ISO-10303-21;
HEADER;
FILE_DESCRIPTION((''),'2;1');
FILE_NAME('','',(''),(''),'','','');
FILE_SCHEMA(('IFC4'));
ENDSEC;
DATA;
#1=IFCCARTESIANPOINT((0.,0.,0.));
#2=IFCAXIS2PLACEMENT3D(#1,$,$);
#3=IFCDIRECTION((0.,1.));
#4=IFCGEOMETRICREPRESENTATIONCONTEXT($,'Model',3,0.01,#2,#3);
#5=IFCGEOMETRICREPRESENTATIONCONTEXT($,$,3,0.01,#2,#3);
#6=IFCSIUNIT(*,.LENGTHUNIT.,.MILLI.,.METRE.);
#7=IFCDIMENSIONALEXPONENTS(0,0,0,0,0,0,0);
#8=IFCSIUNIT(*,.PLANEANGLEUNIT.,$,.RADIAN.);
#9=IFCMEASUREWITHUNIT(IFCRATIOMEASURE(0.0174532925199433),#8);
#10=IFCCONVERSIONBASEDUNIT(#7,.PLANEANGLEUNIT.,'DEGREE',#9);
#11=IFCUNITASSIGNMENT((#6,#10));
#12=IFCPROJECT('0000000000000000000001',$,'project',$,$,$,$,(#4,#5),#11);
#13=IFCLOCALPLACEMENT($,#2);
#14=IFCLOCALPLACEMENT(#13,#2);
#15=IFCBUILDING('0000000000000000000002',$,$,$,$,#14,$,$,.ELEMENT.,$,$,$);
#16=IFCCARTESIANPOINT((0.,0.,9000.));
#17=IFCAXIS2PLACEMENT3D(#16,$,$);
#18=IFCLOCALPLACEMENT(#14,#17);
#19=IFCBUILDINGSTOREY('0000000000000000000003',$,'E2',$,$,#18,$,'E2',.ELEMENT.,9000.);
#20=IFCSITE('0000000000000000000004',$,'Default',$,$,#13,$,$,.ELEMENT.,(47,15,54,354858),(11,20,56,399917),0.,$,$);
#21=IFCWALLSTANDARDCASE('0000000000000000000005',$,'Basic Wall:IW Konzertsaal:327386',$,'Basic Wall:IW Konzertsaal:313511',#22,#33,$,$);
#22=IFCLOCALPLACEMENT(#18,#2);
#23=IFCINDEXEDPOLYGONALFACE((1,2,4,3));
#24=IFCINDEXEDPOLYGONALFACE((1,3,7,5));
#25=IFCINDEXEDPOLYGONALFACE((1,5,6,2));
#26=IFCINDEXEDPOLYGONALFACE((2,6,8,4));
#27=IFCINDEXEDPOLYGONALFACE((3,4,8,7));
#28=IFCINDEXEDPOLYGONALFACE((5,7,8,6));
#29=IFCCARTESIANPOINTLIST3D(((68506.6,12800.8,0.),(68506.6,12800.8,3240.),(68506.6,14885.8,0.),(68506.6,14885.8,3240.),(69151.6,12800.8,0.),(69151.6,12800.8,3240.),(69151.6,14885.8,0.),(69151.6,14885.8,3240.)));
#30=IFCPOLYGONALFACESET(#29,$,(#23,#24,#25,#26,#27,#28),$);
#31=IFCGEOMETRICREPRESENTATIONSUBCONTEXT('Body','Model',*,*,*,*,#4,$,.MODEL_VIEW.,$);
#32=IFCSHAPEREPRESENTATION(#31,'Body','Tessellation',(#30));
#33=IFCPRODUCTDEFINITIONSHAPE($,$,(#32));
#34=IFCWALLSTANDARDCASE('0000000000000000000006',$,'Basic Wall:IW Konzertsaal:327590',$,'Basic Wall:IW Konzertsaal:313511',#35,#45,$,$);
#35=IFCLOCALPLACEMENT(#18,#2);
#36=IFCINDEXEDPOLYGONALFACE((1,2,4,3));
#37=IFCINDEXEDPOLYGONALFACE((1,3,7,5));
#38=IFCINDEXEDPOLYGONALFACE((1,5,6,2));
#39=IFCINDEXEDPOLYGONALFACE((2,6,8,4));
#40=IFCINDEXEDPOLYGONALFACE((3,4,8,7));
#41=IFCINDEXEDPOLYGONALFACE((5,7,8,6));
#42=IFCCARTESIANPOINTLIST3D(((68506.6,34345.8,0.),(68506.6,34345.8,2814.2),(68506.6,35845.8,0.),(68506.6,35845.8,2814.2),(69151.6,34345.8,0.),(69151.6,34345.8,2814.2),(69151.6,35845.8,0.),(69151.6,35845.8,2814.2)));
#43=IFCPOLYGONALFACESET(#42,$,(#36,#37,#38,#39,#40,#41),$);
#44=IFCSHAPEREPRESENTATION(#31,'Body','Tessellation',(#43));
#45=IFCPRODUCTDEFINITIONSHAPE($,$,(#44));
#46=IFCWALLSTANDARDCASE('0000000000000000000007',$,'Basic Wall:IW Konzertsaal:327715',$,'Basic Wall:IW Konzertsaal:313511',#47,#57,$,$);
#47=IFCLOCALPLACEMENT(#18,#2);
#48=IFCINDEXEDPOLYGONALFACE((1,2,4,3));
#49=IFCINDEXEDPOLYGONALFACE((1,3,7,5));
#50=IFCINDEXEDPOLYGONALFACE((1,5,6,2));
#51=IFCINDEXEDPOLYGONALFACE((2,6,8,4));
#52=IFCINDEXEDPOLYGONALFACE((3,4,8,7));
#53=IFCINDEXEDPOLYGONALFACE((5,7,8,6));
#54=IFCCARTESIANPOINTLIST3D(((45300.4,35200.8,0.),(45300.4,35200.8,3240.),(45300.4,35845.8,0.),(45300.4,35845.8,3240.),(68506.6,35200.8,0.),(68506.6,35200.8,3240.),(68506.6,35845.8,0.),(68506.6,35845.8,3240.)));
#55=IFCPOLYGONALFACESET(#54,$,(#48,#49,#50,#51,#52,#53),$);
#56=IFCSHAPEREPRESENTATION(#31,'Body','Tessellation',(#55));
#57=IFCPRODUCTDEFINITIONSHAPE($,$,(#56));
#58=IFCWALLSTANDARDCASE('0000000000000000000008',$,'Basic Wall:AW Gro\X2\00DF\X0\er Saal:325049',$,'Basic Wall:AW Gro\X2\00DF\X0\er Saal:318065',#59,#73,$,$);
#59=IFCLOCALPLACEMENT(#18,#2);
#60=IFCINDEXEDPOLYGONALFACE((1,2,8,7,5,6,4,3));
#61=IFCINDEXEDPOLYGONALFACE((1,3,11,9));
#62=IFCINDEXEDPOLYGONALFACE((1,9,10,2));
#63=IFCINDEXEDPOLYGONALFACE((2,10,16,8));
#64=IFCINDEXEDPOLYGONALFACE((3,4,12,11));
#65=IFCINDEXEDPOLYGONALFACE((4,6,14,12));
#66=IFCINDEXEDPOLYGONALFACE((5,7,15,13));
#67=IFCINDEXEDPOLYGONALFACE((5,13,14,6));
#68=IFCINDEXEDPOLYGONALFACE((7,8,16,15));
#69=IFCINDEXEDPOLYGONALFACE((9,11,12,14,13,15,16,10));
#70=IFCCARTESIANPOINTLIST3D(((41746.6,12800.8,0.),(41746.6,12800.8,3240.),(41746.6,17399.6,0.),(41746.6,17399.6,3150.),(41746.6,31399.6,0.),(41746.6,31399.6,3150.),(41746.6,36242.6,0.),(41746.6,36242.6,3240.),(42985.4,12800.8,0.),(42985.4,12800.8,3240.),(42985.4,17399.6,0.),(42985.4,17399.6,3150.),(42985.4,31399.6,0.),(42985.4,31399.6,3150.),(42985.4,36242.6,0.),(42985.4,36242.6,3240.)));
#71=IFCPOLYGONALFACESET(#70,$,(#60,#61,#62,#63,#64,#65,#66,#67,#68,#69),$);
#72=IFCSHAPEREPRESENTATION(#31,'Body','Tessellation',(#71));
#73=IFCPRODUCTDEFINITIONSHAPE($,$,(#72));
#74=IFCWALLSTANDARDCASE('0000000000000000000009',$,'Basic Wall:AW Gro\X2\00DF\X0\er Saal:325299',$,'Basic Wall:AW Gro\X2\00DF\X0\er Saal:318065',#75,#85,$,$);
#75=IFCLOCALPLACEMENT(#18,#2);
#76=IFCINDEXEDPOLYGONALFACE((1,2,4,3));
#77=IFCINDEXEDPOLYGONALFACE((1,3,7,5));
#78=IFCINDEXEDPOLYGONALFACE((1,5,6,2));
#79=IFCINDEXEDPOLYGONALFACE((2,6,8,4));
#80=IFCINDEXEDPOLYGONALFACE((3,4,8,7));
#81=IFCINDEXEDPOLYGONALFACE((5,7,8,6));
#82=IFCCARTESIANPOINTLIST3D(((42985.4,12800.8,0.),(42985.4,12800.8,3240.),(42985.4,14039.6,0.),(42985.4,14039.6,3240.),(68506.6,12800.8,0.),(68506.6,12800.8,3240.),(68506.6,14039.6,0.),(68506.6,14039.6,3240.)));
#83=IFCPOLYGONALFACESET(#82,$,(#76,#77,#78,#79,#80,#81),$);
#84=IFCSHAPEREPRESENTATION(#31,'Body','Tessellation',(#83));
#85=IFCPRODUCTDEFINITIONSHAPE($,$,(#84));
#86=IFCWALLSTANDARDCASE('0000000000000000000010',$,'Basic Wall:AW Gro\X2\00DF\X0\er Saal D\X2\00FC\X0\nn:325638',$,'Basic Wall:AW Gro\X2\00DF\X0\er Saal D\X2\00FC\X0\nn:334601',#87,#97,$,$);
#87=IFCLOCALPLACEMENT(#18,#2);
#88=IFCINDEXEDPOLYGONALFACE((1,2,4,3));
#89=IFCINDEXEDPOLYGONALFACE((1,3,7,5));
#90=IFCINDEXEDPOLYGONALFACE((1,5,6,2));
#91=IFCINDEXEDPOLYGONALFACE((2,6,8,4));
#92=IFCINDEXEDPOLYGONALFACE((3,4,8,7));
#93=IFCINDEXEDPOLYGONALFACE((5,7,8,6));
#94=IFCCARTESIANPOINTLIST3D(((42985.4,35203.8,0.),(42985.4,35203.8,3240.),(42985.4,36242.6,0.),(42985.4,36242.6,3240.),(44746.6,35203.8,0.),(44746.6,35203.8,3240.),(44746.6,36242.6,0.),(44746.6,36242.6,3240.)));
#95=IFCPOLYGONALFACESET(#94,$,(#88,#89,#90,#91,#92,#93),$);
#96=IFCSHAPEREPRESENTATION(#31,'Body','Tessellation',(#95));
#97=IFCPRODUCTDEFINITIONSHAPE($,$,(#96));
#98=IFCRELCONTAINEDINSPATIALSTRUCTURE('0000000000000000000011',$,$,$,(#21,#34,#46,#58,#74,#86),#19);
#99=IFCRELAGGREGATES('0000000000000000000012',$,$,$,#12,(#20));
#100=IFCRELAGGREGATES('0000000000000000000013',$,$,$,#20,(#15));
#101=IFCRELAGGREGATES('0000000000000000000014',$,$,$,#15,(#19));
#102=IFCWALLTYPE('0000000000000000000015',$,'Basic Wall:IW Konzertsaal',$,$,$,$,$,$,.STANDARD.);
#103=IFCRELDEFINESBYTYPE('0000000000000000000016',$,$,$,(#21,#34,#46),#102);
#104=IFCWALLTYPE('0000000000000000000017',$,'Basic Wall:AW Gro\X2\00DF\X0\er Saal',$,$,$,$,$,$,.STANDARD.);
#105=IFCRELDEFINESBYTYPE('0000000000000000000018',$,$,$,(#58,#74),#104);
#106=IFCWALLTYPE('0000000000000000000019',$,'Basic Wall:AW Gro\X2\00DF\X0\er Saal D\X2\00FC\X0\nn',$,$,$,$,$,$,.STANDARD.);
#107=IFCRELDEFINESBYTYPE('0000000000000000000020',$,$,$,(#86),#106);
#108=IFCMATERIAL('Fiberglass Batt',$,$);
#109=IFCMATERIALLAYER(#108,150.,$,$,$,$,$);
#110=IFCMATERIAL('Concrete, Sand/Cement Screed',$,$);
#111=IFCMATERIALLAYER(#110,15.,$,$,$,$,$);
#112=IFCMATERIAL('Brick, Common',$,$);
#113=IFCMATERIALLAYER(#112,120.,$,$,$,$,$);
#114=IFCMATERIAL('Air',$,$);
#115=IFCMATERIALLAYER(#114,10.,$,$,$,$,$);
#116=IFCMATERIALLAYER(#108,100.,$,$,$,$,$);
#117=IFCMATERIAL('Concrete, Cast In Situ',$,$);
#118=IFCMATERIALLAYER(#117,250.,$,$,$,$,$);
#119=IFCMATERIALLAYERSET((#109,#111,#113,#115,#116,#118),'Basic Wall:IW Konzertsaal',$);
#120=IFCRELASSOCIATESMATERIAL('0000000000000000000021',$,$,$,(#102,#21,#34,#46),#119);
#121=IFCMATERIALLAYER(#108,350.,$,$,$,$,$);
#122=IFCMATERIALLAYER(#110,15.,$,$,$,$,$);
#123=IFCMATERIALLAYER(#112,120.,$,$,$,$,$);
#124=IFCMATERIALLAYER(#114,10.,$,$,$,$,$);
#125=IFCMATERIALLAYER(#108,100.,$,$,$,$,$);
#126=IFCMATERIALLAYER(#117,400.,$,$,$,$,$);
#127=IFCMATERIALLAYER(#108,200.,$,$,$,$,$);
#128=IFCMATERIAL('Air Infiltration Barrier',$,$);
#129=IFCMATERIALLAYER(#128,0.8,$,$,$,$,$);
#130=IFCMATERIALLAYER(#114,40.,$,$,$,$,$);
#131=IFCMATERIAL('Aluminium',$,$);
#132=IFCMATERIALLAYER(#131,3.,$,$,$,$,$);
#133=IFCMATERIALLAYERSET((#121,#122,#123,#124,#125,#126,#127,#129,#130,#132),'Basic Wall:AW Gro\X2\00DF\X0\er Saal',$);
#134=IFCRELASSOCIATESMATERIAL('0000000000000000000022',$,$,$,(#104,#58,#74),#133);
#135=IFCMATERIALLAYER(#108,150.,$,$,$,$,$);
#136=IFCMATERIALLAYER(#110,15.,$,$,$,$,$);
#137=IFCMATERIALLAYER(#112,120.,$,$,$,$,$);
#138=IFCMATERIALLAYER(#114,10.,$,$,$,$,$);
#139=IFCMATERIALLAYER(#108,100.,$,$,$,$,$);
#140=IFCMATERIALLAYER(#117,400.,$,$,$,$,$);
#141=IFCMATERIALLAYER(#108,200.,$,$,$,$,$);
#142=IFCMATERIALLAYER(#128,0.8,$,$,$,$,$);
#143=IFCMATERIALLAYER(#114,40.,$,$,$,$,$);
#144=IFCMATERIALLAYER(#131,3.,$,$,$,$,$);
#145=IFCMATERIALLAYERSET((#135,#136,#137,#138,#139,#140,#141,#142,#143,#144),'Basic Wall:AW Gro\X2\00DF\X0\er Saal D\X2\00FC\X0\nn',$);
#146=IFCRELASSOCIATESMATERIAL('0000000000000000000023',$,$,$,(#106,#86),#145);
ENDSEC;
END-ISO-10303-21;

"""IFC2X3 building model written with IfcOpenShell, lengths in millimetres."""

from ifc_helpers import new_model, entity, si_unit, converted_unit, direction, frame, frame_2d, origin, place, context, subcontext, project, spatial, polyline, rectangle, extrude, clip, bounded_halfspace, material, layer, layer_set, layer_usage, type_object, element, save


model = new_model("IFC2X3")

# Units and contexts
model_context = context("Model", 3, precision=0.01, world=origin(), true_north=direction((0.0, 1.0)))
context_of_model = context(None, 3, precision=0.01, world=origin(), true_north=direction((0.0, 1.0)))
body_context = subcontext(model_context, "Body", "Model", "MODEL_VIEW")
ifc_project = project(units=[si_unit("LENGTHUNIT", "METRE", prefix="MILLI"), converted_unit("PLANEANGLEUNIT", "DEGREE", entity("IfcRatioMeasure", 0.0174532925199433), si_unit("PLANEANGLEUNIT", "RADIAN"), dimensions=[0, 0, 0, 0, 0, 0, 0])], contexts=[model_context, context_of_model])

# Site, building, storey
site_placement = place(None, origin())
site = spatial("IfcSite", under=ifc_project, at=site_placement, Name="Default", CompositionType="ELEMENT", RefLatitude=(47, 15, 54, 354858), RefLongitude=(11, 20, 56, 399917), RefElevation=0.0)
building_placement = place(site_placement, origin())
building = spatial("IfcBuilding", under=site, at=building_placement, CompositionType="ELEMENT")
storey_placement = place(building_placement, frame((0.0, 0.0, 9000.0)))
storey = spatial("IfcBuildingStorey", under=building, at=storey_placement, Name="E2", LongName="E2", CompositionType="ELEMENT", Elevation=9000.0)

# Shared definitions
ifc_material_1 = material(Name="Concrete, Sand/Cement Screed")
ifc_material_2 = material(Name="Air Infiltration Barrier")
ifc_material_3 = material(Name="Fiberglass Batt")

# Shared definitions
ifc_material_4 = material(Name="Concrete, Cast In Situ")

# Shared definitions
ifc_material_5 = material(Name="Air")
ifc_material_6 = material(Name="Aluminium")

# Walls
ifc_layer_1 = layer(ifc_material_3, 150.0)
ifc_layer_2 = layer(ifc_material_1, 15.0)
ifc_material_7 = material(Name="Brick, Common")
ifc_layer_3 = layer(ifc_material_7, 120.0)
ifc_layer_4 = layer(ifc_material_5, 10.0)
ifc_layer_5 = layer(ifc_material_3, 100.0)
ifc_layer_6 = layer(ifc_material_4, 250.0)
ifc_layer_set_1 = layer_set([ifc_layer_1, ifc_layer_2, ifc_layer_3, ifc_layer_4, ifc_layer_5, ifc_layer_6], Name="Basic Wall:IW Konzertsaal")
wall_type_1 = type_object("IfcWallType", Name="Basic Wall:IW Konzertsaal", PredefinedType="STANDARD", material=ifc_layer_set_1)
ifc_layer_usage_1 = layer_usage(ifc_layer_set_1, "AXIS2", "NEGATIVE", 322.5)
wall_1_placement = place(storey_placement, frame((68829.1, 12800.8, 0.0), z_axis=(0.0, 0.0, 1.0), x_axis=(0.0, 1.0, 0.0)))
element("IfcWallStandardCase", 1, at=wall_1_placement, inside=storey, type_object=wall_type_1, material=ifc_layer_usage_1, Name="Basic Wall:IW Konzertsaal:327386", ObjectType="Basic Wall:IW Konzertsaal:313511", context=body_context, shape_type="SweptSolid", body=[
    extrude(rectangle(XDim=2085.0, YDim=645.0, at=frame_2d((1042.5, 0.0), x_axis=(-1.0, 0.0))), origin(), (0.0, 0.0, 1.0), 3240.0),
])
ifc_layer_usage_2 = layer_usage(ifc_layer_set_1, "AXIS2", "NEGATIVE", 322.5)
wall_2_placement = place(storey_placement, frame((68829.1, 34345.8, 0.0), z_axis=(0.0, 0.0, 1.0), x_axis=(0.0, 1.0, 0.0)))
element("IfcWallStandardCase", 2, at=wall_2_placement, inside=storey, type_object=wall_type_1, material=ifc_layer_usage_2, Name="Basic Wall:IW Konzertsaal:327590", ObjectType="Basic Wall:IW Konzertsaal:313511", context=body_context, shape_type="Clipping", body=[
    clip(extrude(rectangle(XDim=1500.0, YDim=645.0, at=frame_2d((750.0, 0.0), x_axis=(-1.0, 0.0))), origin(), (0.0, 0.0, 1.0), 2814.2), bounded_halfspace(frame((0.0, -322.5, 2814.2), z_axis=(0.0, 0.0, -1.0), x_axis=(0.0, -1.0, 0.0)), True, frame((0.0, -322.5, 2814.2)), polyline([(0.0, 0.0), (855.0, 0.0), (855.0, 645.0), (0.0, 645.0), (0.0, 0.0)]))),
])
ifc_layer_usage_3 = layer_usage(ifc_layer_set_1, "AXIS2", "NEGATIVE", 322.5)
wall_3_placement = place(storey_placement, frame((68506.6, 35523.3, 0.0), z_axis=(0.0, 0.0, 1.0), x_axis=(-1.0, 0.0, 0.0)))
element("IfcWallStandardCase", 3, at=wall_3_placement, inside=storey, type_object=wall_type_1, material=ifc_layer_usage_3, Name="Basic Wall:IW Konzertsaal:327715", ObjectType="Basic Wall:IW Konzertsaal:313511", context=body_context, shape_type="SweptSolid", body=[
    extrude(rectangle(XDim=23206.2, YDim=645.0, at=frame_2d((11603.1, 0.0), x_axis=(-1.0, 0.0))), origin(), (0.0, 0.0, 1.0), 3240.0),
])

# Wall, opening
ifc_layer_7 = layer(ifc_material_3, 350.0)
ifc_layer_8 = layer(ifc_material_1, 15.0)
ifc_layer_9 = layer(ifc_material_7, 120.0)
ifc_layer_10 = layer(ifc_material_5, 10.0)
ifc_layer_11 = layer(ifc_material_3, 100.0)
ifc_layer_12 = layer(ifc_material_4, 400.0)
ifc_layer_13 = layer(ifc_material_3, 200.0)
ifc_layer_14 = layer(ifc_material_2, 0.8)
ifc_layer_15 = layer(ifc_material_5, 40.0)
ifc_layer_16 = layer(ifc_material_6, 3.0)
ifc_layer_set_2 = layer_set([ifc_layer_7, ifc_layer_8, ifc_layer_9, ifc_layer_10, ifc_layer_11, ifc_layer_12, ifc_layer_13, ifc_layer_14, ifc_layer_15, ifc_layer_16], Name="Basic Wall:AW Großer Saal")
ifc_layer_usage_4 = layer_usage(ifc_layer_set_2, "AXIS2", "NEGATIVE", 619.4)
wall_type_2 = type_object("IfcWallType", Name="Basic Wall:AW Großer Saal", PredefinedType="STANDARD", material=ifc_layer_set_2)
wall_4_placement = place(storey_placement, frame((42366.0, 36242.6, 0.0), z_axis=(0.0, 0.0, 1.0), x_axis=(0.0, -1.0, 0.0)))
wall_4 = element("IfcWallStandardCase", 4, at=wall_4_placement, inside=storey, type_object=wall_type_2, material=ifc_layer_usage_4, Name="Basic Wall:AW Großer Saal:325049", ObjectType="Basic Wall:AW Großer Saal:318065", context=body_context, shape_type="SweptSolid", body=[
    extrude(rectangle(XDim=23441.7, YDim=1238.8, at=frame_2d((11720.9, 0.0), x_axis=(-1.0, 0.0))), origin(), (0.0, 0.0, 1.0), 3240.0),
])
opening_1_placement = place(wall_4_placement, frame((18842.9, 619.4, 0.0)))
element("IfcOpeningElement", 5, at=opening_1_placement, cuts=wall_4, ObjectType="Opening", context=body_context, shape_type="SweptSolid", body=[
    extrude(rectangle(XDim=3150.0, YDim=14000.0, at=frame_2d((1575.0, 7000.0), x_axis=(-1.0, 0.0))), frame((0.0, 0.0, 0.0), z_axis=(0.0, -1.0, 0.0), x_axis=(0.0, 0.0, 1.0)), (0.0, 0.0, 1.0), 1238.8),
])

# Walls
ifc_layer_usage_5 = layer_usage(ifc_layer_set_2, "AXIS2", "NEGATIVE", 619.4)
wall_5_placement = place(storey_placement, frame((42985.4, 13420.2, 0.0)))
element("IfcWallStandardCase", 6, at=wall_5_placement, inside=storey, type_object=wall_type_2, material=ifc_layer_usage_5, Name="Basic Wall:AW Großer Saal:325299", ObjectType="Basic Wall:AW Großer Saal:318065", context=body_context, shape_type="SweptSolid", body=[
    extrude(rectangle(XDim=25521.2, YDim=1238.8, at=frame_2d((12760.6, 0.0), x_axis=(-1.0, 0.0))), origin(), (0.0, 0.0, 1.0), 3240.0),
])
ifc_layer_17 = layer(ifc_material_3, 150.0)
ifc_layer_18 = layer(ifc_material_1, 15.0)
ifc_layer_19 = layer(ifc_material_7, 120.0)
ifc_layer_20 = layer(ifc_material_5, 10.0)
ifc_layer_21 = layer(ifc_material_3, 100.0)
ifc_layer_22 = layer(ifc_material_4, 400.0)
ifc_layer_23 = layer(ifc_material_3, 200.0)
ifc_layer_24 = layer(ifc_material_2, 0.8)
ifc_layer_25 = layer(ifc_material_5, 40.0)
ifc_layer_26 = layer(ifc_material_6, 3.0)
ifc_layer_set_3 = layer_set([ifc_layer_17, ifc_layer_18, ifc_layer_19, ifc_layer_20, ifc_layer_21, ifc_layer_22, ifc_layer_23, ifc_layer_24, ifc_layer_25, ifc_layer_26], Name="Basic Wall:AW Großer Saal Dünn")
ifc_layer_usage_6 = layer_usage(ifc_layer_set_3, "AXIS2", "NEGATIVE", 519.4)
wall_type_3 = type_object("IfcWallType", Name="Basic Wall:AW Großer Saal Dünn", PredefinedType="STANDARD", material=ifc_layer_set_3)
wall_6_placement = place(storey_placement, frame((44746.6, 35723.2, 0.0), z_axis=(0.0, 0.0, 1.0), x_axis=(-1.0, 0.0, 0.0)))
element("IfcWallStandardCase", 7, at=wall_6_placement, inside=storey, type_object=wall_type_3, material=ifc_layer_usage_6, Name="Basic Wall:AW Großer Saal Dünn:325638", ObjectType="Basic Wall:AW Großer Saal Dünn:334601", context=body_context, shape_type="SweptSolid", body=[
    extrude(rectangle(XDim=1038.8, YDim=1761.2, at=frame_2d((0.0, 0.0), x_axis=(1.0, 0.0))), frame((880.6, 0.0, 0.0), z_axis=(0.0, 0.0, 1.0), x_axis=(0.0, 1.0, 0.0)), (0.0, 0.0, 1.0), 3240.0),
])

save(model, "model.ifc")
